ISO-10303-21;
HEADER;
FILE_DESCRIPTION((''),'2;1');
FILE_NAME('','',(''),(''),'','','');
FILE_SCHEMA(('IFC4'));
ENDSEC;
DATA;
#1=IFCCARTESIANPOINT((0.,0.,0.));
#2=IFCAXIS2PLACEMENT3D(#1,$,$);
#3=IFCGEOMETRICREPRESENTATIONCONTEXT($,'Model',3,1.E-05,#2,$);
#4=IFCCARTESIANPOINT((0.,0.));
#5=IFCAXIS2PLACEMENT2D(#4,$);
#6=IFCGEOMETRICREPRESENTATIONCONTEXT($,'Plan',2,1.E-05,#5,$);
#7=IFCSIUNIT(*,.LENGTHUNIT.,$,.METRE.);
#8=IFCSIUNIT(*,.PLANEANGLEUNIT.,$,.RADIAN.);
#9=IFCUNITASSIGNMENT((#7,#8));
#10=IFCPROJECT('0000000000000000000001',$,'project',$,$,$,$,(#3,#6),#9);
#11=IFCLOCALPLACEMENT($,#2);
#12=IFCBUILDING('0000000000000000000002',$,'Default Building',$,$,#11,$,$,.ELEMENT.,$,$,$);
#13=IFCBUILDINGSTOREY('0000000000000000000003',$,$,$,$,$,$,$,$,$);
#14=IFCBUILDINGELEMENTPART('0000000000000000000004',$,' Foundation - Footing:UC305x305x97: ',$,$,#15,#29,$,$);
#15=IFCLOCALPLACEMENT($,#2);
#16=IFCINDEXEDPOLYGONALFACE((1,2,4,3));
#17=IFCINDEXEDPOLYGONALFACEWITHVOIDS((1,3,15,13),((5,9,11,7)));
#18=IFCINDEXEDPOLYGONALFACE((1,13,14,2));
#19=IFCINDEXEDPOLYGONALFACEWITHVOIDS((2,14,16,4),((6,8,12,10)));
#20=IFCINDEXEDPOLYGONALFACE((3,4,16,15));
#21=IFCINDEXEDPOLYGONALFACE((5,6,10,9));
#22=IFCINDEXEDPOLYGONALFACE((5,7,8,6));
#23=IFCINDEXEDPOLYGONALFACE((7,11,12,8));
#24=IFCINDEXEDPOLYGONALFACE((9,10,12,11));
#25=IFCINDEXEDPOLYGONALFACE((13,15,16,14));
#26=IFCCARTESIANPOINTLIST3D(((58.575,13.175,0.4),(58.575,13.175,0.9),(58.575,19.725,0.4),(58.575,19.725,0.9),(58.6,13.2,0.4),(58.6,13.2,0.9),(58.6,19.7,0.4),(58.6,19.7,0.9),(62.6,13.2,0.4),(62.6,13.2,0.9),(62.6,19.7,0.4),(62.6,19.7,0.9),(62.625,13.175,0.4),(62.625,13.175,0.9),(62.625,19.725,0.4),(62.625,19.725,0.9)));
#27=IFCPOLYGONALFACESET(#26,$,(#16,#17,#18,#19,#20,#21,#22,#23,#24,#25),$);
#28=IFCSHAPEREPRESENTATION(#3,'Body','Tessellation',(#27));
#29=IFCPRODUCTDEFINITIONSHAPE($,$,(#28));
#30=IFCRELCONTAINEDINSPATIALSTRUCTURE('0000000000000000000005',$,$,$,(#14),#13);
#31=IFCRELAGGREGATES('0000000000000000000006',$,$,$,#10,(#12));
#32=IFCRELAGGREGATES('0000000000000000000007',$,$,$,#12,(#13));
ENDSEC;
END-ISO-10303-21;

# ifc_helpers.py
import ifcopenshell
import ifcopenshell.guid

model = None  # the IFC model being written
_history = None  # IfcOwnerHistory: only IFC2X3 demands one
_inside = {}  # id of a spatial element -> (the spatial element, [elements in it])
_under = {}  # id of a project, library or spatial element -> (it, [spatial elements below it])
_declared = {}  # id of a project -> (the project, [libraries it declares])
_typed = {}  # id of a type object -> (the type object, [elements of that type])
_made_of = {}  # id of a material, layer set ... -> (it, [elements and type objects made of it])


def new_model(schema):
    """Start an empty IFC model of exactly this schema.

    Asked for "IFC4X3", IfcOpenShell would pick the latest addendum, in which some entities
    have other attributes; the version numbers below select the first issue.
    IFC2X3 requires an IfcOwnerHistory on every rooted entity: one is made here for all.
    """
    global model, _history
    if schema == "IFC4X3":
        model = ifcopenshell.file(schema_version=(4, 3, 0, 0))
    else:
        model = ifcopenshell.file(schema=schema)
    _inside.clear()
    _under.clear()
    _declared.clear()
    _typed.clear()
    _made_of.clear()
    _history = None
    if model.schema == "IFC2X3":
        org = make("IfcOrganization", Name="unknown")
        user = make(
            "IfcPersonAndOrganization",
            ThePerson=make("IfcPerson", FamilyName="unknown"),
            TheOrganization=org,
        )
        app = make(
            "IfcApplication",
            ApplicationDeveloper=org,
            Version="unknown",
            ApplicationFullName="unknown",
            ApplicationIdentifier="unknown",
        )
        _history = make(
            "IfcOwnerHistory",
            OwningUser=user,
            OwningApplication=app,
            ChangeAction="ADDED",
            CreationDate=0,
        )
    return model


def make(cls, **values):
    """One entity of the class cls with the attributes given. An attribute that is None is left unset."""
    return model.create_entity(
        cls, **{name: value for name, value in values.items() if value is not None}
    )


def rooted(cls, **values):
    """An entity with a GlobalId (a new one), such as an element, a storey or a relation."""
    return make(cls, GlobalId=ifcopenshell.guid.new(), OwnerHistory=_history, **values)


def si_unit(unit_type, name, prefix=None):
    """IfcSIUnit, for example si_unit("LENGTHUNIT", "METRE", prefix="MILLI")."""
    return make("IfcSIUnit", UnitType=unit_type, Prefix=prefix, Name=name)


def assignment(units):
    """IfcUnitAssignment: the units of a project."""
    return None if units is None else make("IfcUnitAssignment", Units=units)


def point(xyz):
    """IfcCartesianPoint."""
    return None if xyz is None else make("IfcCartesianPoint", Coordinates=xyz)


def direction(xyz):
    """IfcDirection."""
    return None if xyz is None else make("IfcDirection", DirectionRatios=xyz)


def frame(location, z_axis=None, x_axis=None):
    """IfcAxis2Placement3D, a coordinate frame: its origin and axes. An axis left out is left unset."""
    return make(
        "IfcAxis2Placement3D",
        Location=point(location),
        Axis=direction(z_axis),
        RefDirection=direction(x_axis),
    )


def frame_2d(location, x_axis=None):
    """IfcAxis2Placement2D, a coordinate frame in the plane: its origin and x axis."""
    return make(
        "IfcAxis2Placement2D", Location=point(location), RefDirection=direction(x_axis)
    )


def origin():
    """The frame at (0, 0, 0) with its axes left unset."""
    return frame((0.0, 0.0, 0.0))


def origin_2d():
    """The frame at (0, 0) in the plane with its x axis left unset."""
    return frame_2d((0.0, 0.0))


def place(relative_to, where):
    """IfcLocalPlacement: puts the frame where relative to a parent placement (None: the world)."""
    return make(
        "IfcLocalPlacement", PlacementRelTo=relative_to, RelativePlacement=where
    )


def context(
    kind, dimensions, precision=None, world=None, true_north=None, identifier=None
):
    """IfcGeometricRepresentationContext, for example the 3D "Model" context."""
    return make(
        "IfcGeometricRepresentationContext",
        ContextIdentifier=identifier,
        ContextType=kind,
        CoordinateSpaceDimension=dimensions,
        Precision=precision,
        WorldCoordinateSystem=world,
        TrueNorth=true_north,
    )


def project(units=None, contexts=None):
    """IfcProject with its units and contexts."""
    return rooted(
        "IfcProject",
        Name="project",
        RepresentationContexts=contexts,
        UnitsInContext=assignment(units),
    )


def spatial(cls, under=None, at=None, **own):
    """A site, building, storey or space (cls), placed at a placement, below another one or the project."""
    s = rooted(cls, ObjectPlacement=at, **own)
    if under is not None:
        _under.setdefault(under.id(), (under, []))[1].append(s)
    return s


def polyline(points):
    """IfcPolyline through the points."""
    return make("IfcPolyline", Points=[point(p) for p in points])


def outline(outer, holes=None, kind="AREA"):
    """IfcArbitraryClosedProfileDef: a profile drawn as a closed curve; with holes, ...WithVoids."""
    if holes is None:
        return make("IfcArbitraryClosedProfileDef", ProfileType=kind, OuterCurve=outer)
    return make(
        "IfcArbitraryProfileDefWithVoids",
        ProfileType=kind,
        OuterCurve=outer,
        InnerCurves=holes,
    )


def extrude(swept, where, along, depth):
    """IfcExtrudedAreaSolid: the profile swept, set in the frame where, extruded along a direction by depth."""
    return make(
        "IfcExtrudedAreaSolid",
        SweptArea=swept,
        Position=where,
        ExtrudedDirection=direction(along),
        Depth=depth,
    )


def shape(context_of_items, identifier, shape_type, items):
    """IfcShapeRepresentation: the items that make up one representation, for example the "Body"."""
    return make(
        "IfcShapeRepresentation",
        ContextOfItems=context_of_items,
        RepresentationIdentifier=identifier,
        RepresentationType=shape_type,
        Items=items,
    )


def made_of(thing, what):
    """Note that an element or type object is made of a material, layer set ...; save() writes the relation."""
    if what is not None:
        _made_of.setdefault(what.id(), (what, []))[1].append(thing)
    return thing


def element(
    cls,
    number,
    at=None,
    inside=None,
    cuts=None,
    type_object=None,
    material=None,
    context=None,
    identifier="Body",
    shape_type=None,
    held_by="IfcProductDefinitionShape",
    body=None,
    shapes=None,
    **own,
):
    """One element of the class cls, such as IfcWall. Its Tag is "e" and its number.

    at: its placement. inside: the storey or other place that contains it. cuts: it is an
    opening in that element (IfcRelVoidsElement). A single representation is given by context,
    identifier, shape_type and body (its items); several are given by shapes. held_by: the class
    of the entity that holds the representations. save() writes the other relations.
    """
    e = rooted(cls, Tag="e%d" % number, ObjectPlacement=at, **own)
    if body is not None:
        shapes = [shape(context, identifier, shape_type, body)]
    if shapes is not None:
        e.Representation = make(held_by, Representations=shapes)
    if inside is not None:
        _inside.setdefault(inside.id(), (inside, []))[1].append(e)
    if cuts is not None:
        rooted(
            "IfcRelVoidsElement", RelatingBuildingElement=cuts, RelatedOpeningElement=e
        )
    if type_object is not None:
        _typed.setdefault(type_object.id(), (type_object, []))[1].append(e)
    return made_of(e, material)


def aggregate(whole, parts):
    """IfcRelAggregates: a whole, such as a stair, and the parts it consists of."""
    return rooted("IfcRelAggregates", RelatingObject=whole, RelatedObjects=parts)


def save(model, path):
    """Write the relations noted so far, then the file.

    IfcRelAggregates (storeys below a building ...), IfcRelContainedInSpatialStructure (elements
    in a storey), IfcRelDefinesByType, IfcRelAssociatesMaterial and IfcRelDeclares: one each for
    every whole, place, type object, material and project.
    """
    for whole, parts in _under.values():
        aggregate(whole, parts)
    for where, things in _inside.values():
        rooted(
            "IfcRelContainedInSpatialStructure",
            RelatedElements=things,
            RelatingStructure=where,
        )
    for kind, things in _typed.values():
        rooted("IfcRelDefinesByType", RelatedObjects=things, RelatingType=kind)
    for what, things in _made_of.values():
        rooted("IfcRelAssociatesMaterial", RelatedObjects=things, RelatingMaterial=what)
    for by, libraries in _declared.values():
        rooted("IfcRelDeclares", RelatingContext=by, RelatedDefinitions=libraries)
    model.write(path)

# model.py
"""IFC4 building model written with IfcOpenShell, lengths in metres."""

from ifc_helpers import new_model, si_unit, origin, origin_2d, place, context, project, spatial, polyline, outline, extrude, element, save


model = new_model("IFC4")

# Units and contexts
model_context = context("Model", 3, precision=1e-05, world=origin())
plan_context = context("Plan", 2, precision=1e-05, world=origin_2d())
ifc_project = project(units=[si_unit("LENGTHUNIT", "METRE"), si_unit("PLANEANGLEUNIT", "RADIAN")], contexts=[model_context, plan_context])

# Building, storey
building_placement = place(None, origin())
building = spatial("IfcBuilding", under=ifc_project, at=building_placement, Name="Default Building", CompositionType="ELEMENT")
storey = spatial("IfcBuildingStorey", under=building)

# Building element part, opening
building_element_part_1 = element("IfcBuildingElementPart", 1, inside=storey, Name=" Foundation - Footing:UC305x305x97: ", context=model_context, shape_type="SweptSolid", body=[
    extrude(outline(polyline([(58.575, 19.725, 0.4), (62.625, 19.725, 0.4), (62.625, 13.175, 0.4), (58.575, 13.175, 0.4), (58.575, 19.725, 0.4)])), None, (0.0, 0.0, 1.0), 0.5),
])
element("IfcOpeningElement", 2, inside=storey, cuts=building_element_part_1, context=model_context, shape_type="SweptSolid", body=[
    extrude(outline(polyline([(58.6, 19.7, 0.4), (62.6, 19.7, 0.4), (62.6, 13.2, 0.4), (58.6, 13.2, 0.4), (58.6, 19.7, 0.4)])), None, (0.0, 0.0, 1.0), 0.5),
])

save(model, "model.ifc")
